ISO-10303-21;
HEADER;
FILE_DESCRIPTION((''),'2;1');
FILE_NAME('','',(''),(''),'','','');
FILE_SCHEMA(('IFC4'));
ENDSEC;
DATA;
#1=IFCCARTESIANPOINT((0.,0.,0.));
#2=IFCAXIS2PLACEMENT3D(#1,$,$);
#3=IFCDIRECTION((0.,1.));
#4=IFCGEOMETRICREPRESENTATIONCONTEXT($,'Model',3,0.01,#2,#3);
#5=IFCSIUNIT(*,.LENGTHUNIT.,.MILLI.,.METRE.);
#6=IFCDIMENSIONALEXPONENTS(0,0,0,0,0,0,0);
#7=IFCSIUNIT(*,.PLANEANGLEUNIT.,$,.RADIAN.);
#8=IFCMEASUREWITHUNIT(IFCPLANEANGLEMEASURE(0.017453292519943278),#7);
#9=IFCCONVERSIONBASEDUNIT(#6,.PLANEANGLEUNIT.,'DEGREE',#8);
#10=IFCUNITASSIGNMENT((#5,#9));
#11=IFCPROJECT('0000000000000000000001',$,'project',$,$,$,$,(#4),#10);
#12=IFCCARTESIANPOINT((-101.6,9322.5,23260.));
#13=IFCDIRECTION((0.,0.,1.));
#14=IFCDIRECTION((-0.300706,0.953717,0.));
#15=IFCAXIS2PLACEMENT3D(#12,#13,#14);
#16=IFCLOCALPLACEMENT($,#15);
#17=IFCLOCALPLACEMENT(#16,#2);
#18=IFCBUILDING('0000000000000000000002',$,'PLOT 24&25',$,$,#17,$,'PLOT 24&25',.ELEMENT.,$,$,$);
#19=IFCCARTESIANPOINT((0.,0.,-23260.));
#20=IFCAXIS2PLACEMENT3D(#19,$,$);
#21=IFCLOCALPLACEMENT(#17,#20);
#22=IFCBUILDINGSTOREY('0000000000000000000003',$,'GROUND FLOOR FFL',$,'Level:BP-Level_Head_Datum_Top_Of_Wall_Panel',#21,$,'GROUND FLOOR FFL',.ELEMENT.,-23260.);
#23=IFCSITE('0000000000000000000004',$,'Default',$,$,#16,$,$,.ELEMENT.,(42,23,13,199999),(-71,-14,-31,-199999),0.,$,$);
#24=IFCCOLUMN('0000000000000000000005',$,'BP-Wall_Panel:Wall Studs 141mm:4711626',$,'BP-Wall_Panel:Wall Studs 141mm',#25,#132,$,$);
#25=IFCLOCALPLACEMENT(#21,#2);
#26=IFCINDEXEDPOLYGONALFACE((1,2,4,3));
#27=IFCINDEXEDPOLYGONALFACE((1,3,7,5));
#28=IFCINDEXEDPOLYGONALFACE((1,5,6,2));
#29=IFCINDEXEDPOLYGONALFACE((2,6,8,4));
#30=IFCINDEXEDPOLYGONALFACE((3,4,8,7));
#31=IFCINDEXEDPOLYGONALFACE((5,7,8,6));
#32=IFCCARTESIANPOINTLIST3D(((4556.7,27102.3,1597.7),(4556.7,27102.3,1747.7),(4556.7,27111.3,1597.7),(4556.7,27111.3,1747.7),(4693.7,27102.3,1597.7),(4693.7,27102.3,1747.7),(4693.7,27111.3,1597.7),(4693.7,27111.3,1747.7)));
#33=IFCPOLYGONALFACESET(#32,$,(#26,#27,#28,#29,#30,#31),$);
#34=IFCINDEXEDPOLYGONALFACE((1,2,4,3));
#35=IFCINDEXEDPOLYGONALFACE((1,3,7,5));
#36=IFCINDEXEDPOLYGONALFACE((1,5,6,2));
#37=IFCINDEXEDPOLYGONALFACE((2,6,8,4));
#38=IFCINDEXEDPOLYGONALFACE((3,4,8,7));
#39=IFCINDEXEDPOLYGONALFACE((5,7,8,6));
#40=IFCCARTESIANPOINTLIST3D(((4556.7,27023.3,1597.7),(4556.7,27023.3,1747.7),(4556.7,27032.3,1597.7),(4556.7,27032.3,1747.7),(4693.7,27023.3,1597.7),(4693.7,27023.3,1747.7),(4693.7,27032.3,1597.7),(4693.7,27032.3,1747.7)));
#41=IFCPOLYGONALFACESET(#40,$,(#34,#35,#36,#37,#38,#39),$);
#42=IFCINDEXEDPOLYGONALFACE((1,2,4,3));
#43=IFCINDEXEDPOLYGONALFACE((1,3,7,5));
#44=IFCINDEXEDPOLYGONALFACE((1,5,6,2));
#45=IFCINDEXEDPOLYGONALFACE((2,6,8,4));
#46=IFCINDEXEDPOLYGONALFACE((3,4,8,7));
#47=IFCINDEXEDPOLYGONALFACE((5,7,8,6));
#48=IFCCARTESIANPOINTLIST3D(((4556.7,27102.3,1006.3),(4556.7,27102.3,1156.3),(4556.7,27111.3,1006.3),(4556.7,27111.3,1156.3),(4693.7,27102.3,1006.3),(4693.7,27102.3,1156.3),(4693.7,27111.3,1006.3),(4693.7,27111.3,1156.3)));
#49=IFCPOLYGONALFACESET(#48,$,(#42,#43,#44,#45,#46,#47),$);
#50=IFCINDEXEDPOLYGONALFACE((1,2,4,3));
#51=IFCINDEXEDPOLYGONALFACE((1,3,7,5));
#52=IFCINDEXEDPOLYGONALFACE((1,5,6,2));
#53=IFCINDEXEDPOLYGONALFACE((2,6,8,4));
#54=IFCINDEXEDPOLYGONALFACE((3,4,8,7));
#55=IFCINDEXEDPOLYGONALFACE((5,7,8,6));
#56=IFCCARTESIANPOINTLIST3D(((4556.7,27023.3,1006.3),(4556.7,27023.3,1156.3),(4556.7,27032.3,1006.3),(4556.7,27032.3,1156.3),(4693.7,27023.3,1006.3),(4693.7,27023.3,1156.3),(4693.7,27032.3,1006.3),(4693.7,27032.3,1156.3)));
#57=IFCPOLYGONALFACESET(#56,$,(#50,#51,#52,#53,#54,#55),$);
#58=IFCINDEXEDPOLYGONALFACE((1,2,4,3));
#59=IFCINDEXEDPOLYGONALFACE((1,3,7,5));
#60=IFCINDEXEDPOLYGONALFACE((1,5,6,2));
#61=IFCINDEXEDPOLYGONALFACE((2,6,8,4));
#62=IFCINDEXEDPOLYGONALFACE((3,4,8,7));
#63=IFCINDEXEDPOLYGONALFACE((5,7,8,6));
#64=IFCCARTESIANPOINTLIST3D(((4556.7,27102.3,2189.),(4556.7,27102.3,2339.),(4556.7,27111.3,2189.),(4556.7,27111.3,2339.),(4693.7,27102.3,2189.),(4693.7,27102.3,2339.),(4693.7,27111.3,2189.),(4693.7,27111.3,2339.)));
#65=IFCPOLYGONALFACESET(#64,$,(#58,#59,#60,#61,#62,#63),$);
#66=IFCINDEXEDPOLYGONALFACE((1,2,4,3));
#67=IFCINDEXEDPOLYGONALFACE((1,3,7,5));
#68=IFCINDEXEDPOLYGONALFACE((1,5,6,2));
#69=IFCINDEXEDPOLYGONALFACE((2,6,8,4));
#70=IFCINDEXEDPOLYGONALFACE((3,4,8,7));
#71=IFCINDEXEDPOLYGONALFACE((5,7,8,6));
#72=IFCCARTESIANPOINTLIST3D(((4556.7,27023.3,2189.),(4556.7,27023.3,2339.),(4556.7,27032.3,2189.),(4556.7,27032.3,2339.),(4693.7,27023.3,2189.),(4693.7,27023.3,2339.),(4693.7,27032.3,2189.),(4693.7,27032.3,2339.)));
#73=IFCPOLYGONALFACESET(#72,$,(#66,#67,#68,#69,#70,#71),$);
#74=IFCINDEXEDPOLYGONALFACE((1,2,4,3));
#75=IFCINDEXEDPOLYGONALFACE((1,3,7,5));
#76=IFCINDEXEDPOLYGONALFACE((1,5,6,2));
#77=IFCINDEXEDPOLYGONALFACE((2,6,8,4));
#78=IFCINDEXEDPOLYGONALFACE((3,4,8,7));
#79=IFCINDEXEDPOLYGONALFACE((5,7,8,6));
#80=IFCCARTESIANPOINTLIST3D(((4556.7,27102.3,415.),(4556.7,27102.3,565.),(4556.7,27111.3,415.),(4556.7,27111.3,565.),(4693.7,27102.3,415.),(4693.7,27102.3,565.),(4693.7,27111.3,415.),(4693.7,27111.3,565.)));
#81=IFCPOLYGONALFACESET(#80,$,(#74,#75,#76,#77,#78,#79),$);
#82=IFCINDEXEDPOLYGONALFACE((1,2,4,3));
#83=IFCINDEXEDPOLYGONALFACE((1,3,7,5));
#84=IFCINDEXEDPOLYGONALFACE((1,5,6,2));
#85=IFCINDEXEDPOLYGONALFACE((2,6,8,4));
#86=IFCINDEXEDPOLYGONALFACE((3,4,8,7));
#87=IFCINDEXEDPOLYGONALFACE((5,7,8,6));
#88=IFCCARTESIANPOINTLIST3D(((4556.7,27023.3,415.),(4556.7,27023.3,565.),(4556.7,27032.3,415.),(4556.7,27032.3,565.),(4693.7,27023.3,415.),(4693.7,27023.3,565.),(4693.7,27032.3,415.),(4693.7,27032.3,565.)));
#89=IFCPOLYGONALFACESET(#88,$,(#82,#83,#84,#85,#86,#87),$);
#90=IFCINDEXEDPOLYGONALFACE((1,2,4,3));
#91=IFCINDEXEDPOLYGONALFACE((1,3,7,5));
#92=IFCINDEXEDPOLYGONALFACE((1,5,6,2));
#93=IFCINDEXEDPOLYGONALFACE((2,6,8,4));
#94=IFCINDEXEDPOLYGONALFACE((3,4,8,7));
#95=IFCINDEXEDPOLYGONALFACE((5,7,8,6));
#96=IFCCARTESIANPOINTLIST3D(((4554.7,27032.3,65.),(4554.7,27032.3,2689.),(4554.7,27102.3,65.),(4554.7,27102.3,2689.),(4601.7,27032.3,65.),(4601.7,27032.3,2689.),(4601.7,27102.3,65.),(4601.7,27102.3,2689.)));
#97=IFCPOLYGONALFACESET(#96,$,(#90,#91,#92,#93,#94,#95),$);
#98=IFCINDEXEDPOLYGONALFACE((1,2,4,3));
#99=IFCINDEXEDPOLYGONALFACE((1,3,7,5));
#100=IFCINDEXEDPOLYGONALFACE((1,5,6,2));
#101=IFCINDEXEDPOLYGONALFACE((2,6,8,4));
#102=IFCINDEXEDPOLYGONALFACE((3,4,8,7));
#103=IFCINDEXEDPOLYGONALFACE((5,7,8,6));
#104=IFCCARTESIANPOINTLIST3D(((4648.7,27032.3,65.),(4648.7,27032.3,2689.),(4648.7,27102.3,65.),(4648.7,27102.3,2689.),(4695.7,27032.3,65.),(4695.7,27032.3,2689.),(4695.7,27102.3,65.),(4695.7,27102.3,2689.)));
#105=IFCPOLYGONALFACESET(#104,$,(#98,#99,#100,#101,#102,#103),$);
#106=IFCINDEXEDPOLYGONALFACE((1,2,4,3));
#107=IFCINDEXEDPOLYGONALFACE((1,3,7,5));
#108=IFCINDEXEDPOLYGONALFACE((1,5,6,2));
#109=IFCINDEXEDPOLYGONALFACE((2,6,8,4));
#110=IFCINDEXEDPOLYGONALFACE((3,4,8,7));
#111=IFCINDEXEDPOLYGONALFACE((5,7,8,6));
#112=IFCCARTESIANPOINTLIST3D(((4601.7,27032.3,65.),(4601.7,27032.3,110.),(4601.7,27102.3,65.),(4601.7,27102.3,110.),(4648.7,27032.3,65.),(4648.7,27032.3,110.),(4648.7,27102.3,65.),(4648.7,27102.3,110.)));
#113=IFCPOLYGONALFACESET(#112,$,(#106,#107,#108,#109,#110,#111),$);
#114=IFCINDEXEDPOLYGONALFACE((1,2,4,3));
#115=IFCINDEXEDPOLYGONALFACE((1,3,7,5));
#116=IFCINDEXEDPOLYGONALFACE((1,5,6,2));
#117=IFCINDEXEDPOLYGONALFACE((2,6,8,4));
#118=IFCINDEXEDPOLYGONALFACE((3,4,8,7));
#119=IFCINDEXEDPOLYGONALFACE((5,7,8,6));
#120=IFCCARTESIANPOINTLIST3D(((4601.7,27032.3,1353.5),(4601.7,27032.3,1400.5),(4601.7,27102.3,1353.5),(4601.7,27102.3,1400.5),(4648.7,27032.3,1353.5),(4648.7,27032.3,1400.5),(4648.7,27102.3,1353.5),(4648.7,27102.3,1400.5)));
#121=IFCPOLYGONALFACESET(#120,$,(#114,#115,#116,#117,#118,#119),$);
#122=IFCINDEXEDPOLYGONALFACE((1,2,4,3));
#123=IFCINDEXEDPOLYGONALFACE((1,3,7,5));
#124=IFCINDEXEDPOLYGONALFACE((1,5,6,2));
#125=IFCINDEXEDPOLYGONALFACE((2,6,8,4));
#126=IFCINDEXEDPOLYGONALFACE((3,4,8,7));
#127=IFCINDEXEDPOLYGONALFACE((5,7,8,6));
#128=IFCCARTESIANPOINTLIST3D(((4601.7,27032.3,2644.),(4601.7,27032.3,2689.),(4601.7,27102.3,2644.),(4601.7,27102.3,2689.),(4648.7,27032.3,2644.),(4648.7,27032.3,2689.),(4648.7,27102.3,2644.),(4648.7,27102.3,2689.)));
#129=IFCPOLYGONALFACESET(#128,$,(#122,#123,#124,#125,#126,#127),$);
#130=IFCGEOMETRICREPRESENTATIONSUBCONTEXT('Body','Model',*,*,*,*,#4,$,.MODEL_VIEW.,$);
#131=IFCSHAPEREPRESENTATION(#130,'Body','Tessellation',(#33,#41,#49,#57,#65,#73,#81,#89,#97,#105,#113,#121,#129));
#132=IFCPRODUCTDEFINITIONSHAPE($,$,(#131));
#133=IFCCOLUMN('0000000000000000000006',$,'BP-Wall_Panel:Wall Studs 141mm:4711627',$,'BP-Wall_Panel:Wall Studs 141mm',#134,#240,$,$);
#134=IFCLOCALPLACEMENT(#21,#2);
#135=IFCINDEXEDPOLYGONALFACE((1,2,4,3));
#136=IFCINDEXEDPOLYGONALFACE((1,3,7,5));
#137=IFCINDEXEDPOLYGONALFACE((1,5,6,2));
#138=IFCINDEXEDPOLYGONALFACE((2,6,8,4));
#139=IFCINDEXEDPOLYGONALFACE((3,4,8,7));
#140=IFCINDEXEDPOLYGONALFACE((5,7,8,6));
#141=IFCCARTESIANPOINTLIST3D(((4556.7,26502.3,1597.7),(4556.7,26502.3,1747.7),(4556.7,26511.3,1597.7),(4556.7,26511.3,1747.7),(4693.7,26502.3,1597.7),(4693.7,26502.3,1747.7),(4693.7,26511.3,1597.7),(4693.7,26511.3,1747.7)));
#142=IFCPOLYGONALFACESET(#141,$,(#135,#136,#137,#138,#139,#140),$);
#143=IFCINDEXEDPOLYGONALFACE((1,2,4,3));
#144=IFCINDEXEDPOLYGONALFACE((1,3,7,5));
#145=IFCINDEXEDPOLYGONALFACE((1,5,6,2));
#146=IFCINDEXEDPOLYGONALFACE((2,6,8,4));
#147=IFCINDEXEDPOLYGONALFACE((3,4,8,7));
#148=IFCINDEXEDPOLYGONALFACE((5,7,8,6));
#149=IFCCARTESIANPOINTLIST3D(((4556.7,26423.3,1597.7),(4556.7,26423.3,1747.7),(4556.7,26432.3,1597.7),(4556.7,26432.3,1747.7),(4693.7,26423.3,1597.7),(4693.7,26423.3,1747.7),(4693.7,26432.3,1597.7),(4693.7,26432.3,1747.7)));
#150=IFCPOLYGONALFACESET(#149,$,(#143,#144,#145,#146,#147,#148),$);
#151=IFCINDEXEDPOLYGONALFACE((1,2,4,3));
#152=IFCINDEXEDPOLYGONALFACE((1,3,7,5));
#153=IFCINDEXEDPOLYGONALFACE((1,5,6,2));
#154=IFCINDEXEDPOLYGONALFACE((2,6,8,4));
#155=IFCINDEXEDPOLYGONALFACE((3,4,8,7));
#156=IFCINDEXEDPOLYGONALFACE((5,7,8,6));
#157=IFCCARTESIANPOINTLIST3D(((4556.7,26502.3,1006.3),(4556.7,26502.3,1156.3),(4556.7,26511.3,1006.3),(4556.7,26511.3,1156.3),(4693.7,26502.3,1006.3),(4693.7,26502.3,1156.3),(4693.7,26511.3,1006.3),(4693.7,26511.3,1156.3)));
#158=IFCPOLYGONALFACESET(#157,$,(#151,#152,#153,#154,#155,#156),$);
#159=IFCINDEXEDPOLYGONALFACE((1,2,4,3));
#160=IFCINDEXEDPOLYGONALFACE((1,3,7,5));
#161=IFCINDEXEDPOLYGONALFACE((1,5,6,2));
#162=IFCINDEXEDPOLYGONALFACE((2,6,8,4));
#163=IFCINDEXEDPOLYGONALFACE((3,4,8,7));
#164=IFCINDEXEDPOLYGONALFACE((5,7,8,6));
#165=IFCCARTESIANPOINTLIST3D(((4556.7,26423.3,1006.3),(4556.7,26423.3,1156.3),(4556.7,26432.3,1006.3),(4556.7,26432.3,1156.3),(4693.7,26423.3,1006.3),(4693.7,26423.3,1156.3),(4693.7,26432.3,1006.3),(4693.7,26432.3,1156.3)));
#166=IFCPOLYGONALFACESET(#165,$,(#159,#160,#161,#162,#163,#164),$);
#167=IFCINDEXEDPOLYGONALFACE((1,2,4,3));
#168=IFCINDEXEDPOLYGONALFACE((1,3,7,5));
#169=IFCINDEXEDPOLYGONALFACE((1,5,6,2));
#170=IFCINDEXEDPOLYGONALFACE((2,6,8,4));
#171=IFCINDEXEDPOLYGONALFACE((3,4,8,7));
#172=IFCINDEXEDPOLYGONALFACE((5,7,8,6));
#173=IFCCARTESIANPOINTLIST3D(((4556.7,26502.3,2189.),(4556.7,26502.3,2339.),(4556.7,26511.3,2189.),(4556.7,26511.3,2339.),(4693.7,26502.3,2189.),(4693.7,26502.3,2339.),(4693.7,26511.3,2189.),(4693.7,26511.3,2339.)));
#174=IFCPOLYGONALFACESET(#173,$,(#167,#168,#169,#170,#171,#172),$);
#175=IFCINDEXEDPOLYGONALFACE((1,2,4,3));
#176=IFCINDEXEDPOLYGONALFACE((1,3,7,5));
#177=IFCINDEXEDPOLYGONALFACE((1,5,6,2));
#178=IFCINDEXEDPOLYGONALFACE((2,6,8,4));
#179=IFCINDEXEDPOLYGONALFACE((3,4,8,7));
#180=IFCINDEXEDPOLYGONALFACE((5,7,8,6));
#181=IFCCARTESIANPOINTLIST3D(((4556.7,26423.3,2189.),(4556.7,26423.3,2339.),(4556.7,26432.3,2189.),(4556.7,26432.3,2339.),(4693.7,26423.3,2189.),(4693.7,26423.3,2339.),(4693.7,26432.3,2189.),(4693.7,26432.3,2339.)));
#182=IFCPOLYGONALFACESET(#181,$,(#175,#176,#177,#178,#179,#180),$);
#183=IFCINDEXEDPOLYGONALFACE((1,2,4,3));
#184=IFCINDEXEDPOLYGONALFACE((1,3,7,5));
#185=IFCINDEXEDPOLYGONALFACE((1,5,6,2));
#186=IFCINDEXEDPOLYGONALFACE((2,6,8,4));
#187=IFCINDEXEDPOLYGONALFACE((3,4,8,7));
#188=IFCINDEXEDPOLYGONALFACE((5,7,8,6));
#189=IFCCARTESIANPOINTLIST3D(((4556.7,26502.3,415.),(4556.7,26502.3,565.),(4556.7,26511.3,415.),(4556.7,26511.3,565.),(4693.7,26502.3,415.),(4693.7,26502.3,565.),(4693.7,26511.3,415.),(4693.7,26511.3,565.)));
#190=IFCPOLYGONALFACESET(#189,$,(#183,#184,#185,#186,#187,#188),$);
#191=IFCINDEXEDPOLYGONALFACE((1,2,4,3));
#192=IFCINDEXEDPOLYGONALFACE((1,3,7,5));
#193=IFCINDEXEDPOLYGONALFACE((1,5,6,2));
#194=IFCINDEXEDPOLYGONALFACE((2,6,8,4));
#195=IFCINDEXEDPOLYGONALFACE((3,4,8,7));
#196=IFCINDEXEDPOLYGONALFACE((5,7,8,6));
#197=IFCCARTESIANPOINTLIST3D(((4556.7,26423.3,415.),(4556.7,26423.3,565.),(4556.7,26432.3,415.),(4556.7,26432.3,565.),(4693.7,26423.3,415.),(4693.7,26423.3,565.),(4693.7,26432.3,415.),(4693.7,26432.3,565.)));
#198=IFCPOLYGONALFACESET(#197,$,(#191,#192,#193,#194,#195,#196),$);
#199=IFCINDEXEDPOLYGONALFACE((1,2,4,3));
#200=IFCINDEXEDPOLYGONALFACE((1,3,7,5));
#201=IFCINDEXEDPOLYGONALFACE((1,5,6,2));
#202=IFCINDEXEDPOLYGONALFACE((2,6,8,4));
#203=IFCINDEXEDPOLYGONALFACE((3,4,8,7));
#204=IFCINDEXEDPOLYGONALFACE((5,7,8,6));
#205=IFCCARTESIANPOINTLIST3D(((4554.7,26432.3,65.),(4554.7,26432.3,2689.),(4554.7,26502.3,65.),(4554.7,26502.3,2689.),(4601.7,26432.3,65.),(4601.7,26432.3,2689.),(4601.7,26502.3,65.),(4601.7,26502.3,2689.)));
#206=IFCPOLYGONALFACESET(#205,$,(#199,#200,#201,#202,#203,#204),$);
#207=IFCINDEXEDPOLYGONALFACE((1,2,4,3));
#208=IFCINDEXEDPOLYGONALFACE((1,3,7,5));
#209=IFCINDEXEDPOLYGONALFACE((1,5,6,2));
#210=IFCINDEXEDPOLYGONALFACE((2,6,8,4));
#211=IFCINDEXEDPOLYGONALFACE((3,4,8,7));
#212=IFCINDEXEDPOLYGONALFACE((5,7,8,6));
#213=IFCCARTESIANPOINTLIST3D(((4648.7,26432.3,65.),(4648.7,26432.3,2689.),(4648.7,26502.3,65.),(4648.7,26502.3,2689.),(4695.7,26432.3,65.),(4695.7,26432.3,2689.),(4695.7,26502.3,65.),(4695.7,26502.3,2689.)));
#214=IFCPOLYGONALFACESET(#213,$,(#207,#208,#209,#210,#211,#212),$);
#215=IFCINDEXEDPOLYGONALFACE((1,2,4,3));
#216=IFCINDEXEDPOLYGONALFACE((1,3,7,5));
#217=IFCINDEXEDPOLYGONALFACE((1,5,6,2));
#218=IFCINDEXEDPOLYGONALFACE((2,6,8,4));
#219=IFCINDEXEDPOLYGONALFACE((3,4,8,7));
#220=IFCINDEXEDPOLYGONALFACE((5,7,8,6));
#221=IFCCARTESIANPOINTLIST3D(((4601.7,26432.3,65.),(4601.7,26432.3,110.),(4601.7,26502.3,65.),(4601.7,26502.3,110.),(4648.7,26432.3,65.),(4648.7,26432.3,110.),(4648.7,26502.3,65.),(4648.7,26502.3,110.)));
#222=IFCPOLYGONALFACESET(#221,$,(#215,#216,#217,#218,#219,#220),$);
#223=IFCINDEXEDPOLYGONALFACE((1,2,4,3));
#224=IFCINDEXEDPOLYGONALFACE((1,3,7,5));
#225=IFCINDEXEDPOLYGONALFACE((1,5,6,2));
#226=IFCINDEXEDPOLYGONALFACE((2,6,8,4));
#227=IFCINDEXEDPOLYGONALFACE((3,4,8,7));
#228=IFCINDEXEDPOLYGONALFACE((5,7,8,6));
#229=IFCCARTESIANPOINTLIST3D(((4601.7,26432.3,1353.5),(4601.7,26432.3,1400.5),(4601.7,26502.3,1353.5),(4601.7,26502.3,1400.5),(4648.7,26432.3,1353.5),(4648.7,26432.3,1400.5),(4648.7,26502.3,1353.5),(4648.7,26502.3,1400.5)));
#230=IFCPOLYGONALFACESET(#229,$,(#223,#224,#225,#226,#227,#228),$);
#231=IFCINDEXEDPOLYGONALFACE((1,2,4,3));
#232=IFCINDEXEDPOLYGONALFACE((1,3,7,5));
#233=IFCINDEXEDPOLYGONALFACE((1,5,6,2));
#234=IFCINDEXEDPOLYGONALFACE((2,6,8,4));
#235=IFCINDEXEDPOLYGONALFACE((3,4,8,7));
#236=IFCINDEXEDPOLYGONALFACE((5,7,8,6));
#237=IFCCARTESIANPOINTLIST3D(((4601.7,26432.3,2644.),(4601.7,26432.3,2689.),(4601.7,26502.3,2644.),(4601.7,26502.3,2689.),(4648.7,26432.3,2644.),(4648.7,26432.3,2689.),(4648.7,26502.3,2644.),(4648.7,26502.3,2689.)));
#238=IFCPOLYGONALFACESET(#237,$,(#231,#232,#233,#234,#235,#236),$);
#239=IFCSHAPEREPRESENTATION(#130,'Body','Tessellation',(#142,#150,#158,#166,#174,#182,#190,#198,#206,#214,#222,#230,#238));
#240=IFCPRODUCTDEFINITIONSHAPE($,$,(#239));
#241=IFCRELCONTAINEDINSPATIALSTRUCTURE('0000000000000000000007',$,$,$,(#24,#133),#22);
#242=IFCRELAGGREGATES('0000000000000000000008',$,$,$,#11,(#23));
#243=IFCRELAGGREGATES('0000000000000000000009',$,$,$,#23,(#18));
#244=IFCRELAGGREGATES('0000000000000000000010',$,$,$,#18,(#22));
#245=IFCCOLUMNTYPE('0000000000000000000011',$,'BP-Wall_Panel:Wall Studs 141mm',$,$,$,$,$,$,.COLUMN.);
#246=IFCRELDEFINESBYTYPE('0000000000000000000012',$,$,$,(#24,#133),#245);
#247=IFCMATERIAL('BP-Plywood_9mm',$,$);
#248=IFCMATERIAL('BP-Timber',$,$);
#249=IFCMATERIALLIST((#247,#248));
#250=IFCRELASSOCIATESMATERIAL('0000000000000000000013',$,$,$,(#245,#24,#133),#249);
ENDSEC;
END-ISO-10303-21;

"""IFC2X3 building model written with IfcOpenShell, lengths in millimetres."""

from ifc_helpers import new_model, entity, si_unit, converted_unit, direction, frame, origin, origin_2d_with_axis, place, context, subcontext, project, spatial, rectangle, extrude, source, transform, mapped, material, material_list, type_object, type_shapes, element, save


model = new_model("IFC2X3")

# Units and contexts
model_context = context("Model", 3, precision=0.01, world=origin(), true_north=direction((0.0, 1.0)))
body_context = subcontext(model_context, "Body", "Model", "MODEL_VIEW")
ifc_project = project(units=[si_unit("LENGTHUNIT", "METRE", prefix="MILLI"), converted_unit("PLANEANGLEUNIT", "DEGREE", entity("IfcPlaneAngleMeasure", 0.017453292519943278), si_unit("PLANEANGLEUNIT", "RADIAN"), dimensions=[0, 0, 0, 0, 0, 0, 0])], contexts=[model_context])

# Site, building, storey
site_placement = place(None, frame((-101.6, 9322.5, 23260.0), z_axis=(0.0, 0.0, 1.0), x_axis=(-0.300706, 0.953717, 0.0)))
site = spatial("IfcSite", under=ifc_project, at=site_placement, Name="Default", CompositionType="ELEMENT", RefLatitude=(42, 23, 13, 199999), RefLongitude=(-71, -14, -31, -199999), RefElevation=0.0)
building_placement = place(site_placement, origin())
building = spatial("IfcBuilding", under=site, at=building_placement, Name="PLOT 24&25", LongName="PLOT 24&25", CompositionType="ELEMENT")
storey_placement = place(building_placement, frame((0.0, 0.0, -23260.0)))
storey = spatial("IfcBuildingStorey", under=building, at=storey_placement, Name="GROUND FLOOR FFL", ObjectType="Level:BP-Level_Head_Datum_Top_Of_Wall_Panel", LongName="GROUND FLOOR FFL", CompositionType="ELEMENT", Elevation=-23260.0)

# Columns
ifc_material_1 = material(Name="BP-Plywood_9mm")
ifc_material_2 = material(Name="BP-Timber")
ifc_material_list = material_list([ifc_material_1, ifc_material_2])
column_type_1 = type_object("IfcColumnType", Name="BP-Wall_Panel:Wall Studs 141mm", PredefinedType="COLUMN", material=ifc_material_list)
shared_shape_1 = source(origin(), body_context, "Body", "SweptSolid", [
    extrude(rectangle(XDim=9.0, YDim=137.0, at=origin_2d_with_axis()), frame((39.5, 0.0, -21662.3)), (0.0, 0.0, 1.0), 150.0),
    extrude(rectangle(XDim=137.0, YDim=9.0, at=origin_2d_with_axis()), frame((-39.5, 0.0, -21662.3), z_axis=(0.0, 0.0, 1.0), x_axis=(0.0, 1.0, 0.0)), (0.0, 0.0, 1.0), 150.0),
    extrude(rectangle(XDim=9.0, YDim=137.0, at=origin_2d_with_axis()), frame((39.5, 0.0, -22253.7)), (0.0, 0.0, 1.0), 150.0),
    extrude(rectangle(XDim=137.0, YDim=9.0, at=origin_2d_with_axis()), frame((-39.5, 0.0, -22253.7), z_axis=(0.0, 0.0, 1.0), x_axis=(0.0, 1.0, 0.0)), (0.0, 0.0, 1.0), 150.0),
    extrude(rectangle(XDim=9.0, YDim=137.0, at=origin_2d_with_axis()), frame((39.5, 0.0, -21071.0)), (0.0, 0.0, 1.0), 150.0),
    extrude(rectangle(XDim=137.0, YDim=9.0, at=origin_2d_with_axis()), frame((-39.5, 0.0, -21071.0), z_axis=(0.0, 0.0, 1.0), x_axis=(0.0, 1.0, 0.0)), (0.0, 0.0, 1.0), 150.0),
    extrude(rectangle(XDim=9.0, YDim=137.0, at=origin_2d_with_axis()), frame((39.5, 0.0, -22845.0)), (0.0, 0.0, 1.0), 150.0),
    extrude(rectangle(XDim=137.0, YDim=9.0, at=origin_2d_with_axis()), frame((-39.5, 0.0, -22845.0), z_axis=(0.0, 0.0, 1.0), x_axis=(0.0, 1.0, 0.0)), (0.0, 0.0, 1.0), 150.0),
    extrude(rectangle(XDim=47.0, YDim=70.0, at=origin_2d_with_axis()), frame((0.0, 47.0, -23195.0), z_axis=(0.0, 0.0, 1.0), x_axis=(0.0, 1.0, 0.0)), (0.0, 0.0, 1.0), 2624.0),
    extrude(rectangle(XDim=47.0, YDim=70.0, at=origin_2d_with_axis()), frame((0.0, -47.0, -23195.0), z_axis=(0.0, 0.0, 1.0), x_axis=(0.0, 1.0, 0.0)), (0.0, 0.0, 1.0), 2624.0),
    extrude(rectangle(XDim=70.0, YDim=47.0, at=origin_2d_with_axis()), frame((0.0, 0.0, -23195.0)), (0.0, 0.0, 1.0), 45.0),
    extrude(rectangle(XDim=70.0, YDim=47.0, at=origin_2d_with_axis()), frame((0.0, 0.0, -21906.5)), (0.0, 0.0, 1.0), 47.0),
    extrude(rectangle(XDim=70.0, YDim=47.0, at=origin_2d_with_axis()), frame((0.0, 0.0, -20616.0)), (0.0, 0.0, 1.0), 45.0),
])
type_shapes(column_type_1, [shared_shape_1])
for number, where, z_axis, x_axis, name in (
    (1, (4625.2, 27067.3, 23260.0), (0.0, 0.0, 1.0), (0.0, 1.0, 0.0), "BP-Wall_Panel:Wall Studs 141mm:4711626"),
    (2, (4625.2, 26467.3, 23260.0), (0.0, 0.0, 1.0), (0.0, 1.0, 0.0), "BP-Wall_Panel:Wall Studs 141mm:4711627"),
):
    element("IfcColumn", number, at=place(storey_placement, frame(where, z_axis=z_axis, x_axis=x_axis)), inside=storey, type_object=column_type_1, material=ifc_material_list, Name=name, ObjectType="BP-Wall_Panel:Wall Studs 141mm", context=body_context, shape_type="MappedRepresentation", body=[
        mapped(shared_shape_1, transform((0.0, 0.0, 0.0), scale=1.0)),
    ])

save(model, "model.ifc")
